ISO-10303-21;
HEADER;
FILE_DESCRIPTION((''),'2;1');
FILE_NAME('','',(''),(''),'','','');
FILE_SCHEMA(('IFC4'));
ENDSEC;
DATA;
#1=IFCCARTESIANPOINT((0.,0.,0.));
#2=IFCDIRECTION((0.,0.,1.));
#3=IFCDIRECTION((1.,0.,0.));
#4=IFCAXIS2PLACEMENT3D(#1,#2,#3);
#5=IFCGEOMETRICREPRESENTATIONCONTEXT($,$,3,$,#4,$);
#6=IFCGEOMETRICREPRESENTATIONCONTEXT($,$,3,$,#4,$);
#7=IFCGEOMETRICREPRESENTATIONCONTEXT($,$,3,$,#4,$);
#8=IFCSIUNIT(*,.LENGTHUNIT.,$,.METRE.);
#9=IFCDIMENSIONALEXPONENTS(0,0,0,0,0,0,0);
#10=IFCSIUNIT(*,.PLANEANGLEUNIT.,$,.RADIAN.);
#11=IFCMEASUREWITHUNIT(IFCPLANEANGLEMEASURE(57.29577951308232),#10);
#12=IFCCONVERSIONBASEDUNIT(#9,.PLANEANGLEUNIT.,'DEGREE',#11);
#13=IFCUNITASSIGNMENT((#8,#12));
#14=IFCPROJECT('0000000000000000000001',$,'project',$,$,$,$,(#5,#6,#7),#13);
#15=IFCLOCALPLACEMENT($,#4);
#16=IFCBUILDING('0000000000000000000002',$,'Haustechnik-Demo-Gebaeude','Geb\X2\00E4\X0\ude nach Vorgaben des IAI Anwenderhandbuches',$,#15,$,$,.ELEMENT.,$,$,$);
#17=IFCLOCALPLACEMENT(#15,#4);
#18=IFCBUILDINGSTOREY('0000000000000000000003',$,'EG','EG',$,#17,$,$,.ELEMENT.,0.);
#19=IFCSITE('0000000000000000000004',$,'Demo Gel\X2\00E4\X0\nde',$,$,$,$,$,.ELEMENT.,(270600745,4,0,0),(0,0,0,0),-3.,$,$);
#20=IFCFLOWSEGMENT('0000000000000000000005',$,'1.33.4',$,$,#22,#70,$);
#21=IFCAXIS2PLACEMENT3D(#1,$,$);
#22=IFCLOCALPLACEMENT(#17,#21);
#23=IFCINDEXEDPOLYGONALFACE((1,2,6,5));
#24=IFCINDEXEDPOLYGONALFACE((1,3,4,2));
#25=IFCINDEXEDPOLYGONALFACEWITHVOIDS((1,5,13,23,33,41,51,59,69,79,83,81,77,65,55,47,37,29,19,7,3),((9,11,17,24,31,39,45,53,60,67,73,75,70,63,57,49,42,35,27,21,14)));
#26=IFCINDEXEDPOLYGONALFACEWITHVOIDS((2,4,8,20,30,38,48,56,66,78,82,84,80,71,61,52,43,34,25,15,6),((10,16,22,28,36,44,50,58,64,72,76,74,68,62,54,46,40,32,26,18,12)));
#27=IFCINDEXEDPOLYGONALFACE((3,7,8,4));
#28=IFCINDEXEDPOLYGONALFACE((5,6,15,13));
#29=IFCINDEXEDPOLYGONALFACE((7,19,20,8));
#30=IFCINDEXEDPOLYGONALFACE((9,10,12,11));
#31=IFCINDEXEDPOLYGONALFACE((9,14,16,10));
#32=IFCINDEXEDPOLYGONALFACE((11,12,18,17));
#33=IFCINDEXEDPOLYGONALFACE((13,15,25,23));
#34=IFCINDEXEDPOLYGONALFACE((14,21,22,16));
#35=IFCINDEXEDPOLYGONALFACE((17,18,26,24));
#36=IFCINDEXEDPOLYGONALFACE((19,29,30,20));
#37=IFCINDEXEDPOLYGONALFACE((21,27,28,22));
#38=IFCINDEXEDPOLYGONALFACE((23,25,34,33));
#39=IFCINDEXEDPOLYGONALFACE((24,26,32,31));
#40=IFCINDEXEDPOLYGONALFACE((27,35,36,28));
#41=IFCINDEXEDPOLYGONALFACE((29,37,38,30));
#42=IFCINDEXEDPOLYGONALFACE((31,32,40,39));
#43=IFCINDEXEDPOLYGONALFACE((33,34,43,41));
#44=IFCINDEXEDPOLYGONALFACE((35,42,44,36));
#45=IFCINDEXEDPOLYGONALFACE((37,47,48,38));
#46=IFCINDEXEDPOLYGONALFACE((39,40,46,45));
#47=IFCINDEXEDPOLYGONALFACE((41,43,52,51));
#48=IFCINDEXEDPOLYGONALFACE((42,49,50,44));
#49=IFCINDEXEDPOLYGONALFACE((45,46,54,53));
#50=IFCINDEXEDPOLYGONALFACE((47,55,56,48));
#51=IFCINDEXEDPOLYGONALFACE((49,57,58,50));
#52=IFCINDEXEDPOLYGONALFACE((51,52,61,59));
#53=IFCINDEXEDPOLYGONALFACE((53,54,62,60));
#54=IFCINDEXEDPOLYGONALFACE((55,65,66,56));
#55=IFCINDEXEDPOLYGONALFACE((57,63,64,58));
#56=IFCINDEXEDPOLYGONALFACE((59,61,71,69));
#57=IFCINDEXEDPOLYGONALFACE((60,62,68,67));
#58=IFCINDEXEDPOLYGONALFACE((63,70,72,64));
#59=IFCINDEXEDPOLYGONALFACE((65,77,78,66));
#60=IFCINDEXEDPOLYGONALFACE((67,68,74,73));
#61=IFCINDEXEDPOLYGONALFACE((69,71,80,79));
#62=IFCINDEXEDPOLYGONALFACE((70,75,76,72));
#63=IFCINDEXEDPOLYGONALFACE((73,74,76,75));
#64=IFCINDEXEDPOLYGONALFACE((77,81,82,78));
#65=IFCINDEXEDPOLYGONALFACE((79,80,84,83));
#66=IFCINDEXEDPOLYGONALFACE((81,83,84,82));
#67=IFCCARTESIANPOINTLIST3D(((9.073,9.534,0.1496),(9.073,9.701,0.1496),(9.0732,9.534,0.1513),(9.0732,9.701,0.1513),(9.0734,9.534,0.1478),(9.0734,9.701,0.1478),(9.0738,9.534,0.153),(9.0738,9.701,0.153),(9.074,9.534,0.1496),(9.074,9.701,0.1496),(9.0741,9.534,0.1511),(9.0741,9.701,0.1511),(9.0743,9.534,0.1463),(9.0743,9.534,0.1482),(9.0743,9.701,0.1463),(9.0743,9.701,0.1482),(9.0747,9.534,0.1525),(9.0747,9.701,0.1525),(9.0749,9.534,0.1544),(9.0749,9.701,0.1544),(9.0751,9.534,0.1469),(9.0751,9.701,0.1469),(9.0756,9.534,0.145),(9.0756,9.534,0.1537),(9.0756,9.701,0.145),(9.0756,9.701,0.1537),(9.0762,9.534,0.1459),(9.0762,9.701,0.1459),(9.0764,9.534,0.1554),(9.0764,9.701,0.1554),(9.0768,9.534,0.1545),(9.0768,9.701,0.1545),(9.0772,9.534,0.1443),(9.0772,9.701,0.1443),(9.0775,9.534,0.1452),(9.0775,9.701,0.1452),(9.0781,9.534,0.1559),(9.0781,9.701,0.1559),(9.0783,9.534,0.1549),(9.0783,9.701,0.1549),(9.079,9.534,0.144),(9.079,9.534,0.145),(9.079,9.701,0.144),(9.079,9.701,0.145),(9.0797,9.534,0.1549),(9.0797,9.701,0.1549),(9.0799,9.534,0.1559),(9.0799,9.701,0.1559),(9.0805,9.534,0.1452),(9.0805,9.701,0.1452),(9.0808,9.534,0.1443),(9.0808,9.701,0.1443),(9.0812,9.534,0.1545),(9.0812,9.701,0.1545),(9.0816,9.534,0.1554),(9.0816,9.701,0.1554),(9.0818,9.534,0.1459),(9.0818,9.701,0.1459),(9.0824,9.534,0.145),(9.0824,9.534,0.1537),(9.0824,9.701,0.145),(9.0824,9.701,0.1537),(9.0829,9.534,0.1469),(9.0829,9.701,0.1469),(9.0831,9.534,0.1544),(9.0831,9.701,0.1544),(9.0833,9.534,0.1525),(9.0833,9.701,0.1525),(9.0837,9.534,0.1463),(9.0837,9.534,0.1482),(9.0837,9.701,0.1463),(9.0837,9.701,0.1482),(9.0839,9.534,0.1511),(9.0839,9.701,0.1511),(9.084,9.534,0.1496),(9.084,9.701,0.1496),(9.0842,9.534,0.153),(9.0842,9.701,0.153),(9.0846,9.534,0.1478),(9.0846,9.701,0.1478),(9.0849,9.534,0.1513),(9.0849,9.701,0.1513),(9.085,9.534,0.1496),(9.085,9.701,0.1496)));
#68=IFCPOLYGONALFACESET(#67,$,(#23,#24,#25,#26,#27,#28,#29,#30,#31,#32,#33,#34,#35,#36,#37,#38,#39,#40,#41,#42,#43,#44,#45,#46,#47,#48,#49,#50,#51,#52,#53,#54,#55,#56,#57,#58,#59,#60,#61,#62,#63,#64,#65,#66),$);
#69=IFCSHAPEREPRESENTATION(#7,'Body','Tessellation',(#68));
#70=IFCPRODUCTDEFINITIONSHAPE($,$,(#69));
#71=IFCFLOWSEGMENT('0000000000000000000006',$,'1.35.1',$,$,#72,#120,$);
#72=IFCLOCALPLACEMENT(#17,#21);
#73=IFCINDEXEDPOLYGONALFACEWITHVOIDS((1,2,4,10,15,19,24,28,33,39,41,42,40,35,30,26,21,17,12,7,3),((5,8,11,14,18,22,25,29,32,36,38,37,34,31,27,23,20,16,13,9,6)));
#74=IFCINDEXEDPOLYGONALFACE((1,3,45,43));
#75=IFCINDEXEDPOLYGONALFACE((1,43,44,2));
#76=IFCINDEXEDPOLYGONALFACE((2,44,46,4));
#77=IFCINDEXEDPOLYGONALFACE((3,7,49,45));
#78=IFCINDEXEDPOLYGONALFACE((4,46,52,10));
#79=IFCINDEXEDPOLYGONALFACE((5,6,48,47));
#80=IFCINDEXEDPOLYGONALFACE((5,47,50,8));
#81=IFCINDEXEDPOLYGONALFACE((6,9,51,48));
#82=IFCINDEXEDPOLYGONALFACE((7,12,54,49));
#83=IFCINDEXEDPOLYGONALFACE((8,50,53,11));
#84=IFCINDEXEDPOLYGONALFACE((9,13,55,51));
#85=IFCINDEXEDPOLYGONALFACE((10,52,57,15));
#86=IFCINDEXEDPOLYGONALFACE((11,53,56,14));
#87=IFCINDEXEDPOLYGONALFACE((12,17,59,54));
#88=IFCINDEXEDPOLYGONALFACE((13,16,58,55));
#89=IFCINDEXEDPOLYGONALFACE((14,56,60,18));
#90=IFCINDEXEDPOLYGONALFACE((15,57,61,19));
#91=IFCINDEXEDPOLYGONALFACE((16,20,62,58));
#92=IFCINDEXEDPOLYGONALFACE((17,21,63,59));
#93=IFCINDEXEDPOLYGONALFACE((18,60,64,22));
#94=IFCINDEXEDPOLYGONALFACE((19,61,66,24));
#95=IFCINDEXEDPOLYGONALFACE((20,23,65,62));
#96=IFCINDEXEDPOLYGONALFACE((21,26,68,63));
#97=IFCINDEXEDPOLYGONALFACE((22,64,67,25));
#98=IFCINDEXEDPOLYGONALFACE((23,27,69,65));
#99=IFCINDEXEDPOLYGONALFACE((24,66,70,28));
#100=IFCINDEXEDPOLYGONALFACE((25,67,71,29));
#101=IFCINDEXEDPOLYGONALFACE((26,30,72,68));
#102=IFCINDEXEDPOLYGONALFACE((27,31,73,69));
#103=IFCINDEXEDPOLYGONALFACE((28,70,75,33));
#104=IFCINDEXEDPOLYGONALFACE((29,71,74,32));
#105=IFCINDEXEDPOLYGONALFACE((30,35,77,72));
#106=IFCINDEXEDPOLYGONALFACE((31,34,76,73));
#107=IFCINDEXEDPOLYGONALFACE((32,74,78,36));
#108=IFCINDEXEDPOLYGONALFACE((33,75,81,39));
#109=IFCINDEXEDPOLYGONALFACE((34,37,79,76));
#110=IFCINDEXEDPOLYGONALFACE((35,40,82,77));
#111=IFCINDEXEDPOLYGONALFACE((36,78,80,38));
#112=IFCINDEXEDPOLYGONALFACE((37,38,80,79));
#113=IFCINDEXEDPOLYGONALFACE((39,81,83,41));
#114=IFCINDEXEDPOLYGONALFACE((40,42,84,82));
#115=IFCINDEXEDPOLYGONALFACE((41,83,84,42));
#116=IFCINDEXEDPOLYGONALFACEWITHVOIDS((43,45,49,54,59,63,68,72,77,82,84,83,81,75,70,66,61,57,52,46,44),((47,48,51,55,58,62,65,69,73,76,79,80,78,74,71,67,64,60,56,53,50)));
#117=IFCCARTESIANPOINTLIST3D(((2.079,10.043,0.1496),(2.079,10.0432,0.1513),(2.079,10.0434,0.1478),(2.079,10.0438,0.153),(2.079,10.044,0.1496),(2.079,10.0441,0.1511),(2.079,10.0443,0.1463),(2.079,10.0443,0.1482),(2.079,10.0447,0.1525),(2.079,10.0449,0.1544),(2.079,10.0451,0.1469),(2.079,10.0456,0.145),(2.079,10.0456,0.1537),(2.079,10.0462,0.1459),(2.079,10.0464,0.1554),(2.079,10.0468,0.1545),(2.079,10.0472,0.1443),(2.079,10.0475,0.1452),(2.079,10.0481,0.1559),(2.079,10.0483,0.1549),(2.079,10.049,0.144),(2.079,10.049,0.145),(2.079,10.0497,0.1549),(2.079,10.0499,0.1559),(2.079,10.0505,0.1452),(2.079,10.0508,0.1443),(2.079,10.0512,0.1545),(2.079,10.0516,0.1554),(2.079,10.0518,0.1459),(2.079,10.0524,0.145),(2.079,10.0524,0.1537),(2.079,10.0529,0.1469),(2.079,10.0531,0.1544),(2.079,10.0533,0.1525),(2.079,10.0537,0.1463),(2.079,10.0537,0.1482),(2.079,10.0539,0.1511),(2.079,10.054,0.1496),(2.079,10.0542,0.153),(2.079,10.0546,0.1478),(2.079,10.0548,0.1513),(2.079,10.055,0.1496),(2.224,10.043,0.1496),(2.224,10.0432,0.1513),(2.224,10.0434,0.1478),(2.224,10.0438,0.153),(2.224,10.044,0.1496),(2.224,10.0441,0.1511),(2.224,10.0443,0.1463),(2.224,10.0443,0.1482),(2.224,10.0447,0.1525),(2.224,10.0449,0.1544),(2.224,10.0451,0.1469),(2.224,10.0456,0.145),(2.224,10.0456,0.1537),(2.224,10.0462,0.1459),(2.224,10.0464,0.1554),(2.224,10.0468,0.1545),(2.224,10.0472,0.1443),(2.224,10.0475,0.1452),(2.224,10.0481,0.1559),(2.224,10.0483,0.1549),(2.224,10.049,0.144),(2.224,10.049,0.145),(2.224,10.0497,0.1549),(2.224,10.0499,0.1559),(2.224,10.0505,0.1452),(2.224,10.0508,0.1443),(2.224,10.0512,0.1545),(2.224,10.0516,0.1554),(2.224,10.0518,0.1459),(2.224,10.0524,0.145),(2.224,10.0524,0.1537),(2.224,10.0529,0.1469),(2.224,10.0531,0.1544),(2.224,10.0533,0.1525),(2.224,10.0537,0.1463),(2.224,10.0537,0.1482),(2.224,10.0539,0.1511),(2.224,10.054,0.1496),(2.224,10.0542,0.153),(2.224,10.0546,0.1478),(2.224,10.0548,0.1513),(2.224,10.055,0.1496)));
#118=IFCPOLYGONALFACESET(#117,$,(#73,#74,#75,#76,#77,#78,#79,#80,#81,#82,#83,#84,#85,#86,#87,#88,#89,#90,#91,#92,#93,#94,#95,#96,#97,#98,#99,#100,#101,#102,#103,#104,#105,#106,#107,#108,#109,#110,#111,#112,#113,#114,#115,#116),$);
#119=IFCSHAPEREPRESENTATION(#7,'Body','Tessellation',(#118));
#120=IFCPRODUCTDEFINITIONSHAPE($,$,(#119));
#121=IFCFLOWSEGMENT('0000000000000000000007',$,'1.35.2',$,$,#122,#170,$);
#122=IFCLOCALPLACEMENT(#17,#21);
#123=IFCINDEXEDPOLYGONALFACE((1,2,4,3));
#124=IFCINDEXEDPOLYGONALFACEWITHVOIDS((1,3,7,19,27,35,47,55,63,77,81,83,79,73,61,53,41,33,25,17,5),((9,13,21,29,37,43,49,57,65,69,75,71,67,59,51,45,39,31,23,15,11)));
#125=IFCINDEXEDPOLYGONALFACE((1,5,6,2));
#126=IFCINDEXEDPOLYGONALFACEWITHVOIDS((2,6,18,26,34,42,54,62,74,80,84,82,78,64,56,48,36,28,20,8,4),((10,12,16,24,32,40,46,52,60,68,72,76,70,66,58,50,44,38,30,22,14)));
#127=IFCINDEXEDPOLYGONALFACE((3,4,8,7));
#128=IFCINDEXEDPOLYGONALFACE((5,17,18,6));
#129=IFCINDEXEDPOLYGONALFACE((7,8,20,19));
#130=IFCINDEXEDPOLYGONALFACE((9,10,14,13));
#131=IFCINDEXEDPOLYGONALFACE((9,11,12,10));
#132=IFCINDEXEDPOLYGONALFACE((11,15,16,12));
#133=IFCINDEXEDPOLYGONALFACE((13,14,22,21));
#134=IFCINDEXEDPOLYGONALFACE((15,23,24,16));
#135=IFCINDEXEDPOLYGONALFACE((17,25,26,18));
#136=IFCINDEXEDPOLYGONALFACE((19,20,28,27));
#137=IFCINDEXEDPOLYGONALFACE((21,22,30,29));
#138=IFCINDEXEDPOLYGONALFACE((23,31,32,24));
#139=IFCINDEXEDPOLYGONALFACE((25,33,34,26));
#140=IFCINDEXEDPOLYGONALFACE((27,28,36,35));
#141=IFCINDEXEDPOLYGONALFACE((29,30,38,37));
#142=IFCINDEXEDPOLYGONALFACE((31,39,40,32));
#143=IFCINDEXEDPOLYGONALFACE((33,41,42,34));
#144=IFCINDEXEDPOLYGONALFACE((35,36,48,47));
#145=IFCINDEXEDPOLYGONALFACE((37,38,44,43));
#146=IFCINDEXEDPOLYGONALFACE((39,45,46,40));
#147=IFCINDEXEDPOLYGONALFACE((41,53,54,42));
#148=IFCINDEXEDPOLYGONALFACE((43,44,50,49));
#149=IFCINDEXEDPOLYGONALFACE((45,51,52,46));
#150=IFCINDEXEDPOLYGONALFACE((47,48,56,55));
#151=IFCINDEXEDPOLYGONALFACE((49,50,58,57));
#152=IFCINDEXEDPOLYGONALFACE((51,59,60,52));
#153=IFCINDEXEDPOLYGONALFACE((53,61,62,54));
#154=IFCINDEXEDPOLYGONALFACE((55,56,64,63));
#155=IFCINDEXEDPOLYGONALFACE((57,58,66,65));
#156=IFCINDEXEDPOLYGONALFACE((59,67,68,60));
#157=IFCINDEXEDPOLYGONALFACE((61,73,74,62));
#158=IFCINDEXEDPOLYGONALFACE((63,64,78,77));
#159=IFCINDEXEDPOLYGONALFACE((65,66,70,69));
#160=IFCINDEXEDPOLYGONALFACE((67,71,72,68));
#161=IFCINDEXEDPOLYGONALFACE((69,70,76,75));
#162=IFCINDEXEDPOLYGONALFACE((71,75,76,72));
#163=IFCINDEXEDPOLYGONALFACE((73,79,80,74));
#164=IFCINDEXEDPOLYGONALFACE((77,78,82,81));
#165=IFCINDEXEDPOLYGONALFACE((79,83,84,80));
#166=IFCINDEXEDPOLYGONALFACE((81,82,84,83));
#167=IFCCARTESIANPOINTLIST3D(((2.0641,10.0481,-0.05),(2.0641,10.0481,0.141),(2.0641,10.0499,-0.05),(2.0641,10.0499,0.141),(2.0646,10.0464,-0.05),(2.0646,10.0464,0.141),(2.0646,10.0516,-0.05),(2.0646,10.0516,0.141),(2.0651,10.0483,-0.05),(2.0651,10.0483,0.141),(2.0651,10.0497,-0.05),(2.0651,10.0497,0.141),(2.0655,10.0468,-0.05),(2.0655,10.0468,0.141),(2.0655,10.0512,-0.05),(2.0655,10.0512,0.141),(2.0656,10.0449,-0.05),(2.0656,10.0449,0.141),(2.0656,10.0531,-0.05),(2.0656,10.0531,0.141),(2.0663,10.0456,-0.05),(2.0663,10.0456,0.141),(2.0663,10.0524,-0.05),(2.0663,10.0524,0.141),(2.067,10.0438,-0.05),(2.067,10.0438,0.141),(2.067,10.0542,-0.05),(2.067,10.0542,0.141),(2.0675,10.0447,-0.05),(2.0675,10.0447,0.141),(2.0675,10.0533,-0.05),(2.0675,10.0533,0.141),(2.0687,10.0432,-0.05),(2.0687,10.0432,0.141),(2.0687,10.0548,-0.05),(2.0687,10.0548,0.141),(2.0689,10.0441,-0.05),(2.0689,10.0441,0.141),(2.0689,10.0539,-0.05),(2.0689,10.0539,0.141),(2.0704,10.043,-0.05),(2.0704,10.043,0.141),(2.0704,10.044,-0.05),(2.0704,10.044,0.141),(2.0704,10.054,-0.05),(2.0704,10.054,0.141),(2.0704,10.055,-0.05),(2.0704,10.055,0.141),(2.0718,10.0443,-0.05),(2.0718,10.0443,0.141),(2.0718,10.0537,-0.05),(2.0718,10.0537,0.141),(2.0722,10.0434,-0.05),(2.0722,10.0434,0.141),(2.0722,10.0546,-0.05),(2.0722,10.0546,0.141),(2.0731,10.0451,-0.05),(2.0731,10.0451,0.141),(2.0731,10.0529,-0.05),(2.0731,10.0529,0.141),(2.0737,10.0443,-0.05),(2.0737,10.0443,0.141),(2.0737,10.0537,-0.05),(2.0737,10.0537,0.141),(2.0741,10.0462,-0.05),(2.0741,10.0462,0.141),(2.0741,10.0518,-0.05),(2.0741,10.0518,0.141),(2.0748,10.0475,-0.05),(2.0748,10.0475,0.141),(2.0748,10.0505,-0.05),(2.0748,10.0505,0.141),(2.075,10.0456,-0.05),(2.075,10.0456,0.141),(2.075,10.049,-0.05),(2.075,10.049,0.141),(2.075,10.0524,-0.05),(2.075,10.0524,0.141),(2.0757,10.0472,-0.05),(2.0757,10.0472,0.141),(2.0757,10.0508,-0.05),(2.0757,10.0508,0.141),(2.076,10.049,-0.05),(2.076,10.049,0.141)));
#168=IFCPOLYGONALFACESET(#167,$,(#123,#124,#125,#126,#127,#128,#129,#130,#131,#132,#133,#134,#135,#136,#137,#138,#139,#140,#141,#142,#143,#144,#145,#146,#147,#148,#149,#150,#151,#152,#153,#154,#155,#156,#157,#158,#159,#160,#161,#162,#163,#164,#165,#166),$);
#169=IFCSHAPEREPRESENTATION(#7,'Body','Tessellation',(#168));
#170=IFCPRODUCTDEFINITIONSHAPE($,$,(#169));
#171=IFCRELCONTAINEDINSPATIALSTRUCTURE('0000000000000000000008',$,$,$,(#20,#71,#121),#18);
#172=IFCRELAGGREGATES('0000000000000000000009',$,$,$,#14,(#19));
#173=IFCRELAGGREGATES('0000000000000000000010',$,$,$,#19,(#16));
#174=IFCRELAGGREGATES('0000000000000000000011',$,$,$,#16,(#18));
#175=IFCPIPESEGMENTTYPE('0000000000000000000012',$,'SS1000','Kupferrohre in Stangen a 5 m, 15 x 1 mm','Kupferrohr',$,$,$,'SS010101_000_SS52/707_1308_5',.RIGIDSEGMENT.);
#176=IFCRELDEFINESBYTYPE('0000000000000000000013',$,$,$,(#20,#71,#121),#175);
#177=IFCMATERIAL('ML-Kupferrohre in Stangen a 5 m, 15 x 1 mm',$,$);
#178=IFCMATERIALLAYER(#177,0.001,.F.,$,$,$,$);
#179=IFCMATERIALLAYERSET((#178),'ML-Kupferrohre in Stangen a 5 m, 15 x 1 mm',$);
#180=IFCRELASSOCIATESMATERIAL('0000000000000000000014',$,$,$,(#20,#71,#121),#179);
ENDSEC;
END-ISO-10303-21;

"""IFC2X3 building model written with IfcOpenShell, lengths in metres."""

from ifc_helpers import new_model, entity, si_unit, converted_unit, frame, origin_with_axes, origin_2d_with_axis, place, context, project, spatial, hollow_circle, extrude, material, layer, layer_set, layer_usage, type_object, element, save


model = new_model("IFC2X3")

# Units and contexts
context_of_model_1 = context(None, 3, world=origin_with_axes())
context_of_model_2 = context(None, 3, world=origin_with_axes())
context_of_model_3 = context(None, 3, world=origin_with_axes())
ifc_project = project(units=[si_unit("LENGTHUNIT", "METRE"), converted_unit("PLANEANGLEUNIT", "DEGREE", entity("IfcPlaneAngleMeasure", 57.29577951308232), si_unit("PLANEANGLEUNIT", "RADIAN"), dimensions=[0, 0, 0, 0, 0, 0, 0])], contexts=[context_of_model_1, context_of_model_2, context_of_model_3])

# Site, building, storey
site = spatial("IfcSite", under=ifc_project, Name="Demo Gelände", CompositionType="ELEMENT", RefLatitude=(270600745, 4, 0, 0), RefLongitude=(0, 0, 0, 0), RefElevation=-3.0)
building_placement = place(None, origin_with_axes())
building = spatial("IfcBuilding", under=site, at=building_placement, Name="Haustechnik-Demo-Gebaeude", Description="Gebäude nach Vorgaben des IAI Anwenderhandbuches", CompositionType="ELEMENT")
storey_placement = place(building_placement, origin_with_axes())
storey = spatial("IfcBuildingStorey", under=building, at=storey_placement, Name="EG", Description="EG", CompositionType="ELEMENT", Elevation=0.0)

# Flow segments
ifc_material_1 = material(Name="ML-Kupferrohre in Stangen a 5 m, 15 x 1 mm")
ifc_layer_1 = layer(ifc_material_1, 0.001, ventilated=False)
ifc_layer_set_1 = layer_set([ifc_layer_1], Name="ML-Kupferrohre in Stangen a 5 m, 15 x 1 mm")
ifc_layer_usage_1 = layer_usage(ifc_layer_set_1, "AXIS2", "POSITIVE", 0.0)
pipe_segment_type_1 = type_object("IfcPipeSegmentType", Name="SS1000", Description="Kupferrohre in Stangen a 5 m, 15 x 1 mm", ApplicableOccurrence="Kupferrohr", ElementType="SS010101_000_SS52/707_1308_5", PredefinedType="RIGIDSEGMENT")
flow_segment_1_placement = place(storey_placement, frame((9.079, 9.701, 0.15), z_axis=(0.0, -1.0, 0.0), x_axis=(0.0, 0.0, -1.0)))
element("IfcFlowSegment", 1, at=flow_segment_1_placement, inside=storey, type_object=pipe_segment_type_1, material=ifc_layer_usage_1, Name="1.33.4", context=context_of_model_3, shape_type="SweptSolid", body=[
    extrude(hollow_circle(Radius=0.006, WallThickness=0.001, at=origin_2d_with_axis()), origin_with_axes(), (0.0, 0.0, 1.0), 0.1671),
])
flow_segment_2_placement = place(storey_placement, frame((2.224, 10.049, 0.15), z_axis=(-1.0, 0.0, 0.0), x_axis=(0.0, 0.0, -1.0)))
element("IfcFlowSegment", 2, at=flow_segment_2_placement, inside=storey, type_object=pipe_segment_type_1, material=ifc_layer_usage_1, Name="1.35.1", context=context_of_model_3, shape_type="SweptSolid", body=[
    extrude(hollow_circle(Radius=0.006, WallThickness=0.001, at=origin_2d_with_axis()), origin_with_axes(), (0.0, 0.0, 1.0), 0.145),
])
flow_segment_3_placement = place(storey_placement, frame((2.07, 10.049, 0.141), z_axis=(0.0, 0.0, -1.0), x_axis=(1.0, 0.0, 0.0)))
element("IfcFlowSegment", 3, at=flow_segment_3_placement, inside=storey, type_object=pipe_segment_type_1, material=ifc_layer_usage_1, Name="1.35.2", context=context_of_model_3, shape_type="SweptSolid", body=[
    extrude(hollow_circle(Radius=0.006, WallThickness=0.001, at=origin_2d_with_axis()), origin_with_axes(), (0.0, 0.0, 1.0), 0.191),
])

save(model, "model.ifc")
